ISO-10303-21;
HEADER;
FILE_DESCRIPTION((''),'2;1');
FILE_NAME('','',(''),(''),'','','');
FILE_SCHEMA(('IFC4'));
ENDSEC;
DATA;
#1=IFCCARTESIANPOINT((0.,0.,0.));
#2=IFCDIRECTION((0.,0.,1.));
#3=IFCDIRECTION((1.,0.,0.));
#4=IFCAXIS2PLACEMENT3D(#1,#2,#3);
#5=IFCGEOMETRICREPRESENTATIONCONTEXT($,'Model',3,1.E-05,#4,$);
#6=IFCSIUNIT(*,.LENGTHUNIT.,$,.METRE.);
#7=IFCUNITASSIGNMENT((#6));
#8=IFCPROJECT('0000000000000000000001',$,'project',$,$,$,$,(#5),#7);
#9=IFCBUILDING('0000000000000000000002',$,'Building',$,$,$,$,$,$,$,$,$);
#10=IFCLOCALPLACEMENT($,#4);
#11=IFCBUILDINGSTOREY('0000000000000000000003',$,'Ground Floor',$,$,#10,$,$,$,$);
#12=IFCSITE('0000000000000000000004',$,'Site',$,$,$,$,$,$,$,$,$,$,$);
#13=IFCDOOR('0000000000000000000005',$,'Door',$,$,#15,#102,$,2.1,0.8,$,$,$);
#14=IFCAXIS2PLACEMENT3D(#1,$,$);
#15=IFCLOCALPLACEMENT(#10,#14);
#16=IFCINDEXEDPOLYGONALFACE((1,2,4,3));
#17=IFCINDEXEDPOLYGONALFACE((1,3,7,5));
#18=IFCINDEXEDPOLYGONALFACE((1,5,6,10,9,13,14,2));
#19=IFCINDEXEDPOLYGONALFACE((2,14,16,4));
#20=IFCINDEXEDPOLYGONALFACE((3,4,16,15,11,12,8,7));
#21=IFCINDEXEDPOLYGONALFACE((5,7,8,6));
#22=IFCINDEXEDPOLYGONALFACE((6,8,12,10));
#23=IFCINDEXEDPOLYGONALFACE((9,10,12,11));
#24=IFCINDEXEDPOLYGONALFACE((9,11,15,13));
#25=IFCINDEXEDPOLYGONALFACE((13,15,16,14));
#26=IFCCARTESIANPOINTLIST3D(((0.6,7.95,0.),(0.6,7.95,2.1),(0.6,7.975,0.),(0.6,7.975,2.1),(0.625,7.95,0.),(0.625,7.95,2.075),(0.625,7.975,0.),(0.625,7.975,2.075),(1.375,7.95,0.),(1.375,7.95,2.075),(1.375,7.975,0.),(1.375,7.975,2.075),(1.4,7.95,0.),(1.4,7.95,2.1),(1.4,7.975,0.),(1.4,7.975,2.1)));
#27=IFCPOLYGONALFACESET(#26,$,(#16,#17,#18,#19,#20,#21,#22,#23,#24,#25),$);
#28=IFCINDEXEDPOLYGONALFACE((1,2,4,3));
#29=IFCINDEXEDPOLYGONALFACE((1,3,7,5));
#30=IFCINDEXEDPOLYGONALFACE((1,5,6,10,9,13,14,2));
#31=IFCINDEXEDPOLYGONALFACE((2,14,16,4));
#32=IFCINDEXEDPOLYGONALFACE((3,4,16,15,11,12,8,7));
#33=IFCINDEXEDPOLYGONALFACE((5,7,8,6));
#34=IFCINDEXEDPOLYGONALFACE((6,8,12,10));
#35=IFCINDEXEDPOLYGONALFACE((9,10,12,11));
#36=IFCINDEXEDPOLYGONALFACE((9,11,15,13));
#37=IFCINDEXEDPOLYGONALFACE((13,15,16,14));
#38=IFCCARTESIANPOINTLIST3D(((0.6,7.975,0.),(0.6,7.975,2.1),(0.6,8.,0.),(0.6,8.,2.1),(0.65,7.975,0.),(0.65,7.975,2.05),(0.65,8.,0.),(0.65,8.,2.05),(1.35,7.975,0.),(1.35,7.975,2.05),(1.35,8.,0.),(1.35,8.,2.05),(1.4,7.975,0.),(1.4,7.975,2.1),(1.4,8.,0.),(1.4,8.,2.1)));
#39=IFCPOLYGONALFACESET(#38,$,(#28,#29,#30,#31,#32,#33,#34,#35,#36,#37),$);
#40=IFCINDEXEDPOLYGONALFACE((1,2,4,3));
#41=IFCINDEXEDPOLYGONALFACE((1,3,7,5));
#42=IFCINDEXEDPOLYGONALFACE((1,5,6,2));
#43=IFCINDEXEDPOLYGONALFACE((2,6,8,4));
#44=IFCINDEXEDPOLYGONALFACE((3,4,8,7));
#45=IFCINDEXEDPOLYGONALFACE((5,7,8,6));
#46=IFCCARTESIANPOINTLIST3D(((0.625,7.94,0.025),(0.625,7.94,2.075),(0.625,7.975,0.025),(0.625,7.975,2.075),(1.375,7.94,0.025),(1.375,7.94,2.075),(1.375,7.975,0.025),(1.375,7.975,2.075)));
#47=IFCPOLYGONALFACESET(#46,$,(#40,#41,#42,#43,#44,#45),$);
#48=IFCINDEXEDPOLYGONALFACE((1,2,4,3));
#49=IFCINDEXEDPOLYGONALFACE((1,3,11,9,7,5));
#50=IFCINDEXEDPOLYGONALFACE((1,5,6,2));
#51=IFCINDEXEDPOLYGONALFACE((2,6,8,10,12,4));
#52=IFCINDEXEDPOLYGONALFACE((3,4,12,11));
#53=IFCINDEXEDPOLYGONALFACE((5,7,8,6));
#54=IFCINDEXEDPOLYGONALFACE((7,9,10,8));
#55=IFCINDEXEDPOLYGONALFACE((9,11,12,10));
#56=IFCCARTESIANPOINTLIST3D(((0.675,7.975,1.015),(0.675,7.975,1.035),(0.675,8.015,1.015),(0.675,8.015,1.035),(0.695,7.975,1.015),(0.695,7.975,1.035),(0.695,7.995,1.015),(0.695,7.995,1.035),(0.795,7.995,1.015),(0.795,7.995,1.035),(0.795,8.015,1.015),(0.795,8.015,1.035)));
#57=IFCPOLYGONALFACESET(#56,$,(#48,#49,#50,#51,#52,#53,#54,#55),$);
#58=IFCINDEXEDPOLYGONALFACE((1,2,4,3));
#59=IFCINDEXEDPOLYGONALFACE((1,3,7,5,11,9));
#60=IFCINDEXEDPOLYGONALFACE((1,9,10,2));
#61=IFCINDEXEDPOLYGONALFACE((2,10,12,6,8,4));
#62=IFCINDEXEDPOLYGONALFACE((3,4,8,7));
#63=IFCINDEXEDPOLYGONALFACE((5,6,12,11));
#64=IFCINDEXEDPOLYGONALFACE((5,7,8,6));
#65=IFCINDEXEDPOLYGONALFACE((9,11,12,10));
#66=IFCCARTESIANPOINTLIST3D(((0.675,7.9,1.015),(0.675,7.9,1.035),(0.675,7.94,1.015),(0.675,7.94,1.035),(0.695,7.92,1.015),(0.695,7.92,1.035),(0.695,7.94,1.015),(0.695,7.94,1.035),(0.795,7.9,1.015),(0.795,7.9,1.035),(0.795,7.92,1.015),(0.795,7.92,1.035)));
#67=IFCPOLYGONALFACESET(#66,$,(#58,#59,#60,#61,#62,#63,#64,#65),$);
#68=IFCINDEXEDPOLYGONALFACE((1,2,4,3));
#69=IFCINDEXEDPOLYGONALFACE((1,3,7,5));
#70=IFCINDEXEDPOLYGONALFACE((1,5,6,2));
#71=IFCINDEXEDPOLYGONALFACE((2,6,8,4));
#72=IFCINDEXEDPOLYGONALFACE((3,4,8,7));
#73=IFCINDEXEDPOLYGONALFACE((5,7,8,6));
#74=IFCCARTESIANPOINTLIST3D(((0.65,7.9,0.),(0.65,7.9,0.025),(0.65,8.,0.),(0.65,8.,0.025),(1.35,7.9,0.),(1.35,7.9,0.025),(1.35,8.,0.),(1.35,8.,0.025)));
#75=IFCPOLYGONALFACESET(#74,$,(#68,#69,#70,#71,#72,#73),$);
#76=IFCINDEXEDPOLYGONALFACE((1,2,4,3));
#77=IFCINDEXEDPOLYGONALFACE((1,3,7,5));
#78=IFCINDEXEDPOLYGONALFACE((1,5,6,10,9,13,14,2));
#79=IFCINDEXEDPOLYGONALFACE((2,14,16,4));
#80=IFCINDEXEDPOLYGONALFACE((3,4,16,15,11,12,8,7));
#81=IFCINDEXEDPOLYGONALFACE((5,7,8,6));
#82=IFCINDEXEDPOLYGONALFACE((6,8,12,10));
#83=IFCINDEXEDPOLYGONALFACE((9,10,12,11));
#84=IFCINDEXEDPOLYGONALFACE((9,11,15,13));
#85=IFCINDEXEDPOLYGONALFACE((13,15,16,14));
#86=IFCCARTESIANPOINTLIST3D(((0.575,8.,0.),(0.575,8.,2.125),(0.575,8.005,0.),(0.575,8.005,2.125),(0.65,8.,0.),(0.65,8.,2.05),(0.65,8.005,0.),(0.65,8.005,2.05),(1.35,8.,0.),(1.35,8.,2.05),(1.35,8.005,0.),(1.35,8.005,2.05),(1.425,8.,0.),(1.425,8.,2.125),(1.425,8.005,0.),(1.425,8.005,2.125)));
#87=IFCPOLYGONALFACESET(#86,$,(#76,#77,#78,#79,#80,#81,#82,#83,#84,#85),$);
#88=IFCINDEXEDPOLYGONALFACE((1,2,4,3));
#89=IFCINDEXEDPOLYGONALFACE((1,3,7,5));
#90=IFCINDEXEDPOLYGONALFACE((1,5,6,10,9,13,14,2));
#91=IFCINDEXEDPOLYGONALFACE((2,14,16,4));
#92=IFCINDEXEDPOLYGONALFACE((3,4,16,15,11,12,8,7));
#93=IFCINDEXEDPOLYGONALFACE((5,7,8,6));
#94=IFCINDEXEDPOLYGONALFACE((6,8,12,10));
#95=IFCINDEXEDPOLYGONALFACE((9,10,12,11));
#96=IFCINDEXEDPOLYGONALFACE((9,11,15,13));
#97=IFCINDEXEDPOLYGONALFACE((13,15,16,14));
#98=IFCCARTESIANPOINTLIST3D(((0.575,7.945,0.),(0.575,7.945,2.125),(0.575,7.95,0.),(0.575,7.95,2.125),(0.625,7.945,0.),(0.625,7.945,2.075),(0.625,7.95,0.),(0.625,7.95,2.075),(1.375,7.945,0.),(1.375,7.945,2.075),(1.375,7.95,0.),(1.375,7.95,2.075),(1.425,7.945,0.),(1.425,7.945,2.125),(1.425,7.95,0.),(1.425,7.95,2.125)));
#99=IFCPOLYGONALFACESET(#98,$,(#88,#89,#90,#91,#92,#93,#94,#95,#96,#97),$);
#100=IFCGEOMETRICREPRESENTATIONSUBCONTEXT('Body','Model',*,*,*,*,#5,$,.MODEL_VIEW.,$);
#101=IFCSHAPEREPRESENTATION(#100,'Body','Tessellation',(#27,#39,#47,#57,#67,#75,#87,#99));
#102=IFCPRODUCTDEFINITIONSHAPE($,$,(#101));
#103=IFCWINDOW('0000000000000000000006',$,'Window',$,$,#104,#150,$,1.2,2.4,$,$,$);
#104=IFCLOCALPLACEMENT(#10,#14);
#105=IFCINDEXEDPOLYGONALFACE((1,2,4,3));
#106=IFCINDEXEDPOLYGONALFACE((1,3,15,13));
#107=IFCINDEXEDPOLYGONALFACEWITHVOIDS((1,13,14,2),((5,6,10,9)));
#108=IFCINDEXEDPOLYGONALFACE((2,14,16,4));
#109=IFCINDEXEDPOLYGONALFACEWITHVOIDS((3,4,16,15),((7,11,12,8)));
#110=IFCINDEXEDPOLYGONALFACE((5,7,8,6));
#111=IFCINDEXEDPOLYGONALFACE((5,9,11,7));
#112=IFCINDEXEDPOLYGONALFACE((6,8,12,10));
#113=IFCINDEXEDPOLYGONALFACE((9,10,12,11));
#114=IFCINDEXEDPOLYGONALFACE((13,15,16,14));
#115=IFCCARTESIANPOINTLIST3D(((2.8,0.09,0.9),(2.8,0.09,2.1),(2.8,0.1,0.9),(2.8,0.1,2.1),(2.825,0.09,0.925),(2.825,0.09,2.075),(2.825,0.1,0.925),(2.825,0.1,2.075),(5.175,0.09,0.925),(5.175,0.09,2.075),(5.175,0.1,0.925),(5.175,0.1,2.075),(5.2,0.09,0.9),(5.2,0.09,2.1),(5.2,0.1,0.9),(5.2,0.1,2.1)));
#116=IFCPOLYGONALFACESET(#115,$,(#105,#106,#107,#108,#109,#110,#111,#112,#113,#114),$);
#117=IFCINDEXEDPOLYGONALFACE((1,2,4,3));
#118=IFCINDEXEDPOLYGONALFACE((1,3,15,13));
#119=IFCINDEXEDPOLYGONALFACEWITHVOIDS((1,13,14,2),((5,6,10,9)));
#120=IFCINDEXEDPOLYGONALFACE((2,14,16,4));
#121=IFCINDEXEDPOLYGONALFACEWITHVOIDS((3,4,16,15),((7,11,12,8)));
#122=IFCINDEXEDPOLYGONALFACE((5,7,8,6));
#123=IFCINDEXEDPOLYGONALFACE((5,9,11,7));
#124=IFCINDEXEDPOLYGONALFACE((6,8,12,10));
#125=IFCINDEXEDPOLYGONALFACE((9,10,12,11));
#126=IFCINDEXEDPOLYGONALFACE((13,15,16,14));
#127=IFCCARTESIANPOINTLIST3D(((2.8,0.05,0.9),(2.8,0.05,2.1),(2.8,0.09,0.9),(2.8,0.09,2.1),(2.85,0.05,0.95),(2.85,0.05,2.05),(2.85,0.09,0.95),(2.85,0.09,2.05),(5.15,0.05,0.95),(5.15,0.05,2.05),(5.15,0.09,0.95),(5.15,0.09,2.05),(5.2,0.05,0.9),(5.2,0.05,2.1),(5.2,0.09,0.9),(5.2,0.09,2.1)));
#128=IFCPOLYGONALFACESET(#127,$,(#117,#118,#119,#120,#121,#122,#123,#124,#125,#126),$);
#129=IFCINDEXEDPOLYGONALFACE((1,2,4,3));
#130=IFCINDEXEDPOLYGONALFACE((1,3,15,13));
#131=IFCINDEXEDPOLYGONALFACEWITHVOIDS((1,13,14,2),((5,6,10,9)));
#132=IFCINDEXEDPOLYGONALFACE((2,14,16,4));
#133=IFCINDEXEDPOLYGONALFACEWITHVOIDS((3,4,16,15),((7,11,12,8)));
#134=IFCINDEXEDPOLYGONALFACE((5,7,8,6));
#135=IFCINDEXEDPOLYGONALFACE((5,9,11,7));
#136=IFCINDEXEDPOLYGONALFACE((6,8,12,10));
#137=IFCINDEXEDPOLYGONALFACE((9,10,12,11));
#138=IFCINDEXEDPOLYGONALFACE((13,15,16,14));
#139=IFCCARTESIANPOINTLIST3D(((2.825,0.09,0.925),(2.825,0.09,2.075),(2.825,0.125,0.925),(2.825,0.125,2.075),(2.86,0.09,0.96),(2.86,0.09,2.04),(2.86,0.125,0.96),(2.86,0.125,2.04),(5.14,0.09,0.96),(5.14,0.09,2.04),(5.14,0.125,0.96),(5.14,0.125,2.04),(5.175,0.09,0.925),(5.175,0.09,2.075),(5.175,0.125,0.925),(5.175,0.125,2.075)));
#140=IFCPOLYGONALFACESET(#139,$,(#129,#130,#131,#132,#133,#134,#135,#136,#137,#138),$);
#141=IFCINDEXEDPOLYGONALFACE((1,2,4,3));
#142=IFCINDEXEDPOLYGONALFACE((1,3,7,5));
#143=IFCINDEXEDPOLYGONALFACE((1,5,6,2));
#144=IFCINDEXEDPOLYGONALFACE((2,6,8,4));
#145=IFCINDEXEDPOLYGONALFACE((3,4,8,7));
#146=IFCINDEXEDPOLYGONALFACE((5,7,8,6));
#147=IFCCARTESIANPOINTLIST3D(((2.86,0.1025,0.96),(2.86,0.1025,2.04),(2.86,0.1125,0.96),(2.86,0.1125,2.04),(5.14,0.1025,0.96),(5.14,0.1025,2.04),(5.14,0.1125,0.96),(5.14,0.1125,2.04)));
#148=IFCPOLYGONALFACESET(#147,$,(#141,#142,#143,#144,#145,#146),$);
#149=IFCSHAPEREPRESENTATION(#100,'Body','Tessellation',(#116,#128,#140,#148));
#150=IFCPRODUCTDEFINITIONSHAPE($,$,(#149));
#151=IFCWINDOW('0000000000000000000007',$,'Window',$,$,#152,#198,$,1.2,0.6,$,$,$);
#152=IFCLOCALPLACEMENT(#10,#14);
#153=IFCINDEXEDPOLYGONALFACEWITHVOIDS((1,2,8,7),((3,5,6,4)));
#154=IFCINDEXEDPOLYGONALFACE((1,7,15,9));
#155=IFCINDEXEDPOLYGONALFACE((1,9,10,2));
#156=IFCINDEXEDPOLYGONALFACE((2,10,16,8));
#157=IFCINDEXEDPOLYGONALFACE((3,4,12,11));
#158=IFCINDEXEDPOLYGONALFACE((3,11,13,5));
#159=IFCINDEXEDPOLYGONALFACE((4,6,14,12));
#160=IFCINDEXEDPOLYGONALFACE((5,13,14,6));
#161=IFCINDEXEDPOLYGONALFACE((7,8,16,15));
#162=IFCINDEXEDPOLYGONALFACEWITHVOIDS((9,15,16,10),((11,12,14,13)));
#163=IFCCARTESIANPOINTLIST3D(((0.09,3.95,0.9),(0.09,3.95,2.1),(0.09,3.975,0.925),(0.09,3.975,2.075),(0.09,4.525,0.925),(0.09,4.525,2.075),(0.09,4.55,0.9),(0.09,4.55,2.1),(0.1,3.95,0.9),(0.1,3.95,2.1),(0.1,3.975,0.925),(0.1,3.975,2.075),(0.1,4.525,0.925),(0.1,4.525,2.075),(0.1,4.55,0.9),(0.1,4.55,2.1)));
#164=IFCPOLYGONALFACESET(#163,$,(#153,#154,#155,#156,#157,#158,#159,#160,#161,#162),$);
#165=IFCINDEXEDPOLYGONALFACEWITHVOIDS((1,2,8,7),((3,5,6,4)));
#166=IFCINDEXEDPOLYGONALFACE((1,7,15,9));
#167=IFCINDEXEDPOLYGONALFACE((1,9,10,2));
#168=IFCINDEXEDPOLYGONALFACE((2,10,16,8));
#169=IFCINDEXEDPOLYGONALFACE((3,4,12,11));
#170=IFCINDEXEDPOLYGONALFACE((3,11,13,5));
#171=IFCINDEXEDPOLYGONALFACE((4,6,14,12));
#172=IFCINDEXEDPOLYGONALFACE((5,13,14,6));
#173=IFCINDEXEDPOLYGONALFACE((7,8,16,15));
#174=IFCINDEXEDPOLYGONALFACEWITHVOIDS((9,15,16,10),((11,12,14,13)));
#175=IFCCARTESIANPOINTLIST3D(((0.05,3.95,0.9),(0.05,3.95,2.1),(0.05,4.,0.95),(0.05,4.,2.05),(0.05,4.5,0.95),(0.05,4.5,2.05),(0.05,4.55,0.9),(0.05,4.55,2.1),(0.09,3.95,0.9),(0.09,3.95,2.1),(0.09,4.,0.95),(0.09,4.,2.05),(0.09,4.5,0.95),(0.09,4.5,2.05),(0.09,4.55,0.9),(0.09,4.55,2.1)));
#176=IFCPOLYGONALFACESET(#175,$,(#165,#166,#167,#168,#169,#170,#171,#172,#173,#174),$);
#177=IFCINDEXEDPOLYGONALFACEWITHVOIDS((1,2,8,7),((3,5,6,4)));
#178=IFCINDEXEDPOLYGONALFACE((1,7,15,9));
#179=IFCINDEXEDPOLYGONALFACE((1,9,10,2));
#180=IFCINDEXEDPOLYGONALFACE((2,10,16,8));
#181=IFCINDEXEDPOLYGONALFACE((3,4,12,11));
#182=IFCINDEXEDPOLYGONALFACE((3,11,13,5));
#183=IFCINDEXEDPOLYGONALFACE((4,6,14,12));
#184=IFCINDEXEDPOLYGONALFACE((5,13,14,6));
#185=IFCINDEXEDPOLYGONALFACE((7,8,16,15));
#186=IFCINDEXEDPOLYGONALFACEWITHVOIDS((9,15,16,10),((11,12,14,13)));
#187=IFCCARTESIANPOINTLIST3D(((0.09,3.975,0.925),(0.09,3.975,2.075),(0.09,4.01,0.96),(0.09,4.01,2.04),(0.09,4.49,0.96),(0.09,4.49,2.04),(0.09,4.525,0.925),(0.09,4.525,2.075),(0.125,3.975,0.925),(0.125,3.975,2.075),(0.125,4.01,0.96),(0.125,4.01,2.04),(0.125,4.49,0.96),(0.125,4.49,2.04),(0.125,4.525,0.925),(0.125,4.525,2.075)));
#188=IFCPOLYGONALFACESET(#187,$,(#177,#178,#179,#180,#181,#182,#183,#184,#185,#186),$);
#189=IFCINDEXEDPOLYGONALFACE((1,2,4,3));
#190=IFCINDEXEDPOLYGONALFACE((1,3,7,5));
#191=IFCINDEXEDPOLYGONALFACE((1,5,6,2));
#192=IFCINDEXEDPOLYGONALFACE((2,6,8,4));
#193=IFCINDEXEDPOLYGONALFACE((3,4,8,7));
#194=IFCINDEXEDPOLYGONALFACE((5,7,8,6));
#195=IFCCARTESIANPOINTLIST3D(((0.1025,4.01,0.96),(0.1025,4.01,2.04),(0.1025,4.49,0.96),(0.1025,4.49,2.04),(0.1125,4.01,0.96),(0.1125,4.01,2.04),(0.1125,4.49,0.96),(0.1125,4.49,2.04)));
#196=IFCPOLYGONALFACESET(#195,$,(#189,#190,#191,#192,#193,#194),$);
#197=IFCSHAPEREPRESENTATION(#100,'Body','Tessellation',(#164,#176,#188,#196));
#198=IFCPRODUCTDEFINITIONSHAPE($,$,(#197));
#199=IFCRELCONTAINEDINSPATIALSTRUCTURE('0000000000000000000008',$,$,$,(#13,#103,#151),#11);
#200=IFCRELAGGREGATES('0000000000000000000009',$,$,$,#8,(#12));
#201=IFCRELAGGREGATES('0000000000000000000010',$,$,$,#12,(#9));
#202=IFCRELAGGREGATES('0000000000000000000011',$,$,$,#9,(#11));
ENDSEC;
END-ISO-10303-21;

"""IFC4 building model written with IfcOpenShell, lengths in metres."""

from ifc_helpers import new_model, si_unit, frame, origin_with_axes, place, context, subcontext, project, spatial, line, indexed_curve, outline, extrude, element, save


model = new_model("IFC4")

# Units and contexts
model_context = context("Model", 3, precision=1e-05, world=origin_with_axes())
body_context = subcontext(model_context, "Body", "Model", "MODEL_VIEW")
ifc_project = project(units=[si_unit("LENGTHUNIT", "METRE")], contexts=[model_context])

# Site, building, storey
site = spatial("IfcSite", under=ifc_project, Name="Site")
building = spatial("IfcBuilding", under=site, Name="Building")
storey_placement = place(None, origin_with_axes())
storey = spatial("IfcBuildingStorey", under=building, at=storey_placement, Name="Ground Floor")

# Door
door_1_placement = place(storey_placement, frame((1.4, 8.0, 0.0), z_axis=(0.0, 0.0, 1.0), x_axis=(-1.0, 0.0, 0.0)))
element("IfcDoor", 1, at=door_1_placement, inside=storey, Name="Door", OverallHeight=2.1, OverallWidth=0.8, context=body_context, shape_type="SweptSolid", body=[
    extrude(outline(indexed_curve([(0.0, 0.0), (0.0, 2.1), (0.8, 2.1), (0.8, 0.0), (0.775, 0.0), (0.775, 2.075), (0.025, 2.075), (0.025, 0.0)], segments=[line(1, 2, 3, 4, 5, 6, 7, 8, 1)])), frame((0.0, 0.025, 0.0), z_axis=(0.0, -1.0, 0.0), x_axis=(1.0, 0.0, 0.0)), (0.0, 0.0, -1.0), 0.025),
    extrude(outline(indexed_curve([(0.0, 0.0), (0.0, 2.1), (0.8, 2.1), (0.8, 0.0), (0.75, 0.0), (0.75, 2.05), (0.05, 2.05), (0.05, 0.0)], segments=[line(1, 2, 3, 4, 5, 6, 7, 8, 1)])), frame((0.0, 0.0, 0.0), z_axis=(0.0, -1.0, 0.0), x_axis=(1.0, 0.0, 0.0)), (0.0, 0.0, -1.0), 0.025),
    extrude(outline(indexed_curve([(0.0, 0.0), (0.75, 0.0), (0.75, 0.035), (0.0, 0.035)], segments=[line(1, 2, 3, 4, 1)])), frame((0.025, 0.025, 0.025), z_axis=(0.0, 0.0, 1.0), x_axis=(1.0, 0.0, 0.0)), (0.0, 0.0, 1.0), 2.05),
    extrude(outline(indexed_curve([(0.0, 0.0), (0.0, -0.04), (-0.12, -0.04), (-0.12, -0.02), (-0.02, -0.02), (-0.02, 0.0)], segments=[line(1, 2, 3, 4, 5, 6, 1)])), frame((0.725, 0.025, 1.015), z_axis=(0.0, 0.0, 1.0), x_axis=(1.0, 0.0, 0.0)), (0.0, 0.0, 1.0), 0.02),
    extrude(outline(indexed_curve([(0.0, 0.0), (0.0, 0.04), (-0.12, 0.04), (-0.12, 0.02), (-0.02, 0.02), (-0.02, 0.0)], segments=[line(1, 2, 3, 4, 5, 6, 1)])), frame((0.725, 0.06, 1.015), z_axis=(0.0, 0.0, 1.0), x_axis=(1.0, 0.0, 0.0)), (0.0, 0.0, 1.0), 0.02),
    extrude(outline(indexed_curve([(0.0, 0.0), (0.7, 0.0), (0.7, 0.1), (0.0, 0.1)], segments=[line(1, 2, 3, 4, 1)])), frame((0.05, 0.0, 0.0), z_axis=(0.0, 0.0, 1.0), x_axis=(1.0, 0.0, 0.0)), (0.0, 0.0, 1.0), 0.025),
    extrude(outline(indexed_curve([(0.0, 0.0), (0.0, 2.125), (0.85, 2.125), (0.85, 0.0), (0.775, 0.0), (0.775, 2.05), (0.075, 2.05), (0.075, 0.0)], segments=[line(1, 2, 3, 4, 5, 6, 7, 8, 1)])), frame((-0.025, -0.005, 0.0), z_axis=(0.0, -1.0, 0.0), x_axis=(1.0, 0.0, 0.0)), (0.0, 0.0, -1.0), 0.005),
    extrude(outline(indexed_curve([(0.0, 0.0), (0.0, 2.125), (0.85, 2.125), (0.85, 0.0), (0.8, 0.0), (0.8, 2.075), (0.05, 2.075), (0.05, 0.0)], segments=[line(1, 2, 3, 4, 5, 6, 7, 8, 1)])), frame((-0.025, 0.05, 0.0), z_axis=(0.0, -1.0, 0.0), x_axis=(1.0, 0.0, 0.0)), (0.0, 0.0, -1.0), 0.005),
])

# Windows
window_1_placement = place(storey_placement, frame((2.8, 0.0, 0.9), z_axis=(0.0, 0.0, 1.0), x_axis=(1.0, 0.0, 0.0)))
element("IfcWindow", 2, at=window_1_placement, inside=storey, Name="Window", OverallHeight=1.2, OverallWidth=2.4, context=body_context, shape_type="SweptSolid", body=[
    extrude(outline(indexed_curve([(0.0, 0.0), (2.4, 0.0), (2.4, 1.2), (0.0, 1.2)], segments=[line(1, 2, 3, 4, 1)]), holes=[indexed_curve([(0.025, 0.025), (2.375, 0.025), (2.375, 1.175), (0.025, 1.175)], segments=[line(1, 2, 3, 4, 1)])]), frame((0.0, 0.09, 0.0), z_axis=(0.0, -1.0, 0.0), x_axis=(1.0, 0.0, 0.0)), (0.0, 0.0, -1.0), 0.01),
    extrude(outline(indexed_curve([(0.0, 0.0), (2.4, 0.0), (2.4, 1.2), (0.0, 1.2)], segments=[line(1, 2, 3, 4, 1)]), holes=[indexed_curve([(0.05, 0.05), (2.35, 0.05), (2.35, 1.15), (0.05, 1.15)], segments=[line(1, 2, 3, 4, 1)])]), frame((0.0, 0.05, 0.0), z_axis=(0.0, -1.0, 0.0), x_axis=(1.0, 0.0, 0.0)), (0.0, 0.0, -1.0), 0.04),
    extrude(outline(indexed_curve([(0.0, 0.0), (2.35, 0.0), (2.35, 1.15), (0.0, 1.15)], segments=[line(1, 2, 3, 4, 1)]), holes=[indexed_curve([(0.035, 0.035), (2.315, 0.035), (2.315, 1.115), (0.035, 1.115)], segments=[line(1, 2, 3, 4, 1)])]), frame((0.025, 0.09, 0.025), z_axis=(0.0, -1.0, 0.0), x_axis=(1.0, 0.0, 0.0)), (0.0, 0.0, -1.0), 0.035),
    extrude(outline(indexed_curve([(0.035, 0.035), (2.315, 0.035), (2.315, 1.115), (0.035, 1.115)], segments=[line(1, 2, 3, 4, 1)])), frame((0.025, 0.1025, 0.025), z_axis=(0.0, -1.0, 0.0), x_axis=(1.0, 0.0, 0.0)), (0.0, 0.0, -1.0), 0.01),
])
window_2_placement = place(storey_placement, frame((0.0, 4.55, 0.9), z_axis=(0.0, 0.0, 1.0), x_axis=(0.0, -1.0, 0.0)))
element("IfcWindow", 3, at=window_2_placement, inside=storey, Name="Window", OverallHeight=1.2, OverallWidth=0.6, context=body_context, shape_type="SweptSolid", body=[
    extrude(outline(indexed_curve([(0.0, 0.0), (0.6, 0.0), (0.6, 1.2), (0.0, 1.2)], segments=[line(1, 2, 3, 4, 1)]), holes=[indexed_curve([(0.025, 0.025), (0.575, 0.025), (0.575, 1.175), (0.025, 1.175)], segments=[line(1, 2, 3, 4, 1)])]), frame((0.0, 0.09, 0.0), z_axis=(0.0, -1.0, 0.0), x_axis=(1.0, 0.0, 0.0)), (0.0, 0.0, -1.0), 0.01),
    extrude(outline(indexed_curve([(0.0, 0.0), (0.6, 0.0), (0.6, 1.2), (0.0, 1.2)], segments=[line(1, 2, 3, 4, 1)]), holes=[indexed_curve([(0.05, 0.05), (0.55, 0.05), (0.55, 1.15), (0.05, 1.15)], segments=[line(1, 2, 3, 4, 1)])]), frame((0.0, 0.05, 0.0), z_axis=(0.0, -1.0, 0.0), x_axis=(1.0, 0.0, 0.0)), (0.0, 0.0, -1.0), 0.04),
    extrude(outline(indexed_curve([(0.0, 0.0), (0.55, 0.0), (0.55, 1.15), (0.0, 1.15)], segments=[line(1, 2, 3, 4, 1)]), holes=[indexed_curve([(0.035, 0.035), (0.515, 0.035), (0.515, 1.115), (0.035, 1.115)], segments=[line(1, 2, 3, 4, 1)])]), frame((0.025, 0.09, 0.025), z_axis=(0.0, -1.0, 0.0), x_axis=(1.0, 0.0, 0.0)), (0.0, 0.0, -1.0), 0.035),
    extrude(outline(indexed_curve([(0.035, 0.035), (0.515, 0.035), (0.515, 1.115), (0.035, 1.115)], segments=[line(1, 2, 3, 4, 1)])), frame((0.025, 0.1025, 0.025), z_axis=(0.0, -1.0, 0.0), x_axis=(1.0, 0.0, 0.0)), (0.0, 0.0, -1.0), 0.01),
])

save(model, "model.ifc")
